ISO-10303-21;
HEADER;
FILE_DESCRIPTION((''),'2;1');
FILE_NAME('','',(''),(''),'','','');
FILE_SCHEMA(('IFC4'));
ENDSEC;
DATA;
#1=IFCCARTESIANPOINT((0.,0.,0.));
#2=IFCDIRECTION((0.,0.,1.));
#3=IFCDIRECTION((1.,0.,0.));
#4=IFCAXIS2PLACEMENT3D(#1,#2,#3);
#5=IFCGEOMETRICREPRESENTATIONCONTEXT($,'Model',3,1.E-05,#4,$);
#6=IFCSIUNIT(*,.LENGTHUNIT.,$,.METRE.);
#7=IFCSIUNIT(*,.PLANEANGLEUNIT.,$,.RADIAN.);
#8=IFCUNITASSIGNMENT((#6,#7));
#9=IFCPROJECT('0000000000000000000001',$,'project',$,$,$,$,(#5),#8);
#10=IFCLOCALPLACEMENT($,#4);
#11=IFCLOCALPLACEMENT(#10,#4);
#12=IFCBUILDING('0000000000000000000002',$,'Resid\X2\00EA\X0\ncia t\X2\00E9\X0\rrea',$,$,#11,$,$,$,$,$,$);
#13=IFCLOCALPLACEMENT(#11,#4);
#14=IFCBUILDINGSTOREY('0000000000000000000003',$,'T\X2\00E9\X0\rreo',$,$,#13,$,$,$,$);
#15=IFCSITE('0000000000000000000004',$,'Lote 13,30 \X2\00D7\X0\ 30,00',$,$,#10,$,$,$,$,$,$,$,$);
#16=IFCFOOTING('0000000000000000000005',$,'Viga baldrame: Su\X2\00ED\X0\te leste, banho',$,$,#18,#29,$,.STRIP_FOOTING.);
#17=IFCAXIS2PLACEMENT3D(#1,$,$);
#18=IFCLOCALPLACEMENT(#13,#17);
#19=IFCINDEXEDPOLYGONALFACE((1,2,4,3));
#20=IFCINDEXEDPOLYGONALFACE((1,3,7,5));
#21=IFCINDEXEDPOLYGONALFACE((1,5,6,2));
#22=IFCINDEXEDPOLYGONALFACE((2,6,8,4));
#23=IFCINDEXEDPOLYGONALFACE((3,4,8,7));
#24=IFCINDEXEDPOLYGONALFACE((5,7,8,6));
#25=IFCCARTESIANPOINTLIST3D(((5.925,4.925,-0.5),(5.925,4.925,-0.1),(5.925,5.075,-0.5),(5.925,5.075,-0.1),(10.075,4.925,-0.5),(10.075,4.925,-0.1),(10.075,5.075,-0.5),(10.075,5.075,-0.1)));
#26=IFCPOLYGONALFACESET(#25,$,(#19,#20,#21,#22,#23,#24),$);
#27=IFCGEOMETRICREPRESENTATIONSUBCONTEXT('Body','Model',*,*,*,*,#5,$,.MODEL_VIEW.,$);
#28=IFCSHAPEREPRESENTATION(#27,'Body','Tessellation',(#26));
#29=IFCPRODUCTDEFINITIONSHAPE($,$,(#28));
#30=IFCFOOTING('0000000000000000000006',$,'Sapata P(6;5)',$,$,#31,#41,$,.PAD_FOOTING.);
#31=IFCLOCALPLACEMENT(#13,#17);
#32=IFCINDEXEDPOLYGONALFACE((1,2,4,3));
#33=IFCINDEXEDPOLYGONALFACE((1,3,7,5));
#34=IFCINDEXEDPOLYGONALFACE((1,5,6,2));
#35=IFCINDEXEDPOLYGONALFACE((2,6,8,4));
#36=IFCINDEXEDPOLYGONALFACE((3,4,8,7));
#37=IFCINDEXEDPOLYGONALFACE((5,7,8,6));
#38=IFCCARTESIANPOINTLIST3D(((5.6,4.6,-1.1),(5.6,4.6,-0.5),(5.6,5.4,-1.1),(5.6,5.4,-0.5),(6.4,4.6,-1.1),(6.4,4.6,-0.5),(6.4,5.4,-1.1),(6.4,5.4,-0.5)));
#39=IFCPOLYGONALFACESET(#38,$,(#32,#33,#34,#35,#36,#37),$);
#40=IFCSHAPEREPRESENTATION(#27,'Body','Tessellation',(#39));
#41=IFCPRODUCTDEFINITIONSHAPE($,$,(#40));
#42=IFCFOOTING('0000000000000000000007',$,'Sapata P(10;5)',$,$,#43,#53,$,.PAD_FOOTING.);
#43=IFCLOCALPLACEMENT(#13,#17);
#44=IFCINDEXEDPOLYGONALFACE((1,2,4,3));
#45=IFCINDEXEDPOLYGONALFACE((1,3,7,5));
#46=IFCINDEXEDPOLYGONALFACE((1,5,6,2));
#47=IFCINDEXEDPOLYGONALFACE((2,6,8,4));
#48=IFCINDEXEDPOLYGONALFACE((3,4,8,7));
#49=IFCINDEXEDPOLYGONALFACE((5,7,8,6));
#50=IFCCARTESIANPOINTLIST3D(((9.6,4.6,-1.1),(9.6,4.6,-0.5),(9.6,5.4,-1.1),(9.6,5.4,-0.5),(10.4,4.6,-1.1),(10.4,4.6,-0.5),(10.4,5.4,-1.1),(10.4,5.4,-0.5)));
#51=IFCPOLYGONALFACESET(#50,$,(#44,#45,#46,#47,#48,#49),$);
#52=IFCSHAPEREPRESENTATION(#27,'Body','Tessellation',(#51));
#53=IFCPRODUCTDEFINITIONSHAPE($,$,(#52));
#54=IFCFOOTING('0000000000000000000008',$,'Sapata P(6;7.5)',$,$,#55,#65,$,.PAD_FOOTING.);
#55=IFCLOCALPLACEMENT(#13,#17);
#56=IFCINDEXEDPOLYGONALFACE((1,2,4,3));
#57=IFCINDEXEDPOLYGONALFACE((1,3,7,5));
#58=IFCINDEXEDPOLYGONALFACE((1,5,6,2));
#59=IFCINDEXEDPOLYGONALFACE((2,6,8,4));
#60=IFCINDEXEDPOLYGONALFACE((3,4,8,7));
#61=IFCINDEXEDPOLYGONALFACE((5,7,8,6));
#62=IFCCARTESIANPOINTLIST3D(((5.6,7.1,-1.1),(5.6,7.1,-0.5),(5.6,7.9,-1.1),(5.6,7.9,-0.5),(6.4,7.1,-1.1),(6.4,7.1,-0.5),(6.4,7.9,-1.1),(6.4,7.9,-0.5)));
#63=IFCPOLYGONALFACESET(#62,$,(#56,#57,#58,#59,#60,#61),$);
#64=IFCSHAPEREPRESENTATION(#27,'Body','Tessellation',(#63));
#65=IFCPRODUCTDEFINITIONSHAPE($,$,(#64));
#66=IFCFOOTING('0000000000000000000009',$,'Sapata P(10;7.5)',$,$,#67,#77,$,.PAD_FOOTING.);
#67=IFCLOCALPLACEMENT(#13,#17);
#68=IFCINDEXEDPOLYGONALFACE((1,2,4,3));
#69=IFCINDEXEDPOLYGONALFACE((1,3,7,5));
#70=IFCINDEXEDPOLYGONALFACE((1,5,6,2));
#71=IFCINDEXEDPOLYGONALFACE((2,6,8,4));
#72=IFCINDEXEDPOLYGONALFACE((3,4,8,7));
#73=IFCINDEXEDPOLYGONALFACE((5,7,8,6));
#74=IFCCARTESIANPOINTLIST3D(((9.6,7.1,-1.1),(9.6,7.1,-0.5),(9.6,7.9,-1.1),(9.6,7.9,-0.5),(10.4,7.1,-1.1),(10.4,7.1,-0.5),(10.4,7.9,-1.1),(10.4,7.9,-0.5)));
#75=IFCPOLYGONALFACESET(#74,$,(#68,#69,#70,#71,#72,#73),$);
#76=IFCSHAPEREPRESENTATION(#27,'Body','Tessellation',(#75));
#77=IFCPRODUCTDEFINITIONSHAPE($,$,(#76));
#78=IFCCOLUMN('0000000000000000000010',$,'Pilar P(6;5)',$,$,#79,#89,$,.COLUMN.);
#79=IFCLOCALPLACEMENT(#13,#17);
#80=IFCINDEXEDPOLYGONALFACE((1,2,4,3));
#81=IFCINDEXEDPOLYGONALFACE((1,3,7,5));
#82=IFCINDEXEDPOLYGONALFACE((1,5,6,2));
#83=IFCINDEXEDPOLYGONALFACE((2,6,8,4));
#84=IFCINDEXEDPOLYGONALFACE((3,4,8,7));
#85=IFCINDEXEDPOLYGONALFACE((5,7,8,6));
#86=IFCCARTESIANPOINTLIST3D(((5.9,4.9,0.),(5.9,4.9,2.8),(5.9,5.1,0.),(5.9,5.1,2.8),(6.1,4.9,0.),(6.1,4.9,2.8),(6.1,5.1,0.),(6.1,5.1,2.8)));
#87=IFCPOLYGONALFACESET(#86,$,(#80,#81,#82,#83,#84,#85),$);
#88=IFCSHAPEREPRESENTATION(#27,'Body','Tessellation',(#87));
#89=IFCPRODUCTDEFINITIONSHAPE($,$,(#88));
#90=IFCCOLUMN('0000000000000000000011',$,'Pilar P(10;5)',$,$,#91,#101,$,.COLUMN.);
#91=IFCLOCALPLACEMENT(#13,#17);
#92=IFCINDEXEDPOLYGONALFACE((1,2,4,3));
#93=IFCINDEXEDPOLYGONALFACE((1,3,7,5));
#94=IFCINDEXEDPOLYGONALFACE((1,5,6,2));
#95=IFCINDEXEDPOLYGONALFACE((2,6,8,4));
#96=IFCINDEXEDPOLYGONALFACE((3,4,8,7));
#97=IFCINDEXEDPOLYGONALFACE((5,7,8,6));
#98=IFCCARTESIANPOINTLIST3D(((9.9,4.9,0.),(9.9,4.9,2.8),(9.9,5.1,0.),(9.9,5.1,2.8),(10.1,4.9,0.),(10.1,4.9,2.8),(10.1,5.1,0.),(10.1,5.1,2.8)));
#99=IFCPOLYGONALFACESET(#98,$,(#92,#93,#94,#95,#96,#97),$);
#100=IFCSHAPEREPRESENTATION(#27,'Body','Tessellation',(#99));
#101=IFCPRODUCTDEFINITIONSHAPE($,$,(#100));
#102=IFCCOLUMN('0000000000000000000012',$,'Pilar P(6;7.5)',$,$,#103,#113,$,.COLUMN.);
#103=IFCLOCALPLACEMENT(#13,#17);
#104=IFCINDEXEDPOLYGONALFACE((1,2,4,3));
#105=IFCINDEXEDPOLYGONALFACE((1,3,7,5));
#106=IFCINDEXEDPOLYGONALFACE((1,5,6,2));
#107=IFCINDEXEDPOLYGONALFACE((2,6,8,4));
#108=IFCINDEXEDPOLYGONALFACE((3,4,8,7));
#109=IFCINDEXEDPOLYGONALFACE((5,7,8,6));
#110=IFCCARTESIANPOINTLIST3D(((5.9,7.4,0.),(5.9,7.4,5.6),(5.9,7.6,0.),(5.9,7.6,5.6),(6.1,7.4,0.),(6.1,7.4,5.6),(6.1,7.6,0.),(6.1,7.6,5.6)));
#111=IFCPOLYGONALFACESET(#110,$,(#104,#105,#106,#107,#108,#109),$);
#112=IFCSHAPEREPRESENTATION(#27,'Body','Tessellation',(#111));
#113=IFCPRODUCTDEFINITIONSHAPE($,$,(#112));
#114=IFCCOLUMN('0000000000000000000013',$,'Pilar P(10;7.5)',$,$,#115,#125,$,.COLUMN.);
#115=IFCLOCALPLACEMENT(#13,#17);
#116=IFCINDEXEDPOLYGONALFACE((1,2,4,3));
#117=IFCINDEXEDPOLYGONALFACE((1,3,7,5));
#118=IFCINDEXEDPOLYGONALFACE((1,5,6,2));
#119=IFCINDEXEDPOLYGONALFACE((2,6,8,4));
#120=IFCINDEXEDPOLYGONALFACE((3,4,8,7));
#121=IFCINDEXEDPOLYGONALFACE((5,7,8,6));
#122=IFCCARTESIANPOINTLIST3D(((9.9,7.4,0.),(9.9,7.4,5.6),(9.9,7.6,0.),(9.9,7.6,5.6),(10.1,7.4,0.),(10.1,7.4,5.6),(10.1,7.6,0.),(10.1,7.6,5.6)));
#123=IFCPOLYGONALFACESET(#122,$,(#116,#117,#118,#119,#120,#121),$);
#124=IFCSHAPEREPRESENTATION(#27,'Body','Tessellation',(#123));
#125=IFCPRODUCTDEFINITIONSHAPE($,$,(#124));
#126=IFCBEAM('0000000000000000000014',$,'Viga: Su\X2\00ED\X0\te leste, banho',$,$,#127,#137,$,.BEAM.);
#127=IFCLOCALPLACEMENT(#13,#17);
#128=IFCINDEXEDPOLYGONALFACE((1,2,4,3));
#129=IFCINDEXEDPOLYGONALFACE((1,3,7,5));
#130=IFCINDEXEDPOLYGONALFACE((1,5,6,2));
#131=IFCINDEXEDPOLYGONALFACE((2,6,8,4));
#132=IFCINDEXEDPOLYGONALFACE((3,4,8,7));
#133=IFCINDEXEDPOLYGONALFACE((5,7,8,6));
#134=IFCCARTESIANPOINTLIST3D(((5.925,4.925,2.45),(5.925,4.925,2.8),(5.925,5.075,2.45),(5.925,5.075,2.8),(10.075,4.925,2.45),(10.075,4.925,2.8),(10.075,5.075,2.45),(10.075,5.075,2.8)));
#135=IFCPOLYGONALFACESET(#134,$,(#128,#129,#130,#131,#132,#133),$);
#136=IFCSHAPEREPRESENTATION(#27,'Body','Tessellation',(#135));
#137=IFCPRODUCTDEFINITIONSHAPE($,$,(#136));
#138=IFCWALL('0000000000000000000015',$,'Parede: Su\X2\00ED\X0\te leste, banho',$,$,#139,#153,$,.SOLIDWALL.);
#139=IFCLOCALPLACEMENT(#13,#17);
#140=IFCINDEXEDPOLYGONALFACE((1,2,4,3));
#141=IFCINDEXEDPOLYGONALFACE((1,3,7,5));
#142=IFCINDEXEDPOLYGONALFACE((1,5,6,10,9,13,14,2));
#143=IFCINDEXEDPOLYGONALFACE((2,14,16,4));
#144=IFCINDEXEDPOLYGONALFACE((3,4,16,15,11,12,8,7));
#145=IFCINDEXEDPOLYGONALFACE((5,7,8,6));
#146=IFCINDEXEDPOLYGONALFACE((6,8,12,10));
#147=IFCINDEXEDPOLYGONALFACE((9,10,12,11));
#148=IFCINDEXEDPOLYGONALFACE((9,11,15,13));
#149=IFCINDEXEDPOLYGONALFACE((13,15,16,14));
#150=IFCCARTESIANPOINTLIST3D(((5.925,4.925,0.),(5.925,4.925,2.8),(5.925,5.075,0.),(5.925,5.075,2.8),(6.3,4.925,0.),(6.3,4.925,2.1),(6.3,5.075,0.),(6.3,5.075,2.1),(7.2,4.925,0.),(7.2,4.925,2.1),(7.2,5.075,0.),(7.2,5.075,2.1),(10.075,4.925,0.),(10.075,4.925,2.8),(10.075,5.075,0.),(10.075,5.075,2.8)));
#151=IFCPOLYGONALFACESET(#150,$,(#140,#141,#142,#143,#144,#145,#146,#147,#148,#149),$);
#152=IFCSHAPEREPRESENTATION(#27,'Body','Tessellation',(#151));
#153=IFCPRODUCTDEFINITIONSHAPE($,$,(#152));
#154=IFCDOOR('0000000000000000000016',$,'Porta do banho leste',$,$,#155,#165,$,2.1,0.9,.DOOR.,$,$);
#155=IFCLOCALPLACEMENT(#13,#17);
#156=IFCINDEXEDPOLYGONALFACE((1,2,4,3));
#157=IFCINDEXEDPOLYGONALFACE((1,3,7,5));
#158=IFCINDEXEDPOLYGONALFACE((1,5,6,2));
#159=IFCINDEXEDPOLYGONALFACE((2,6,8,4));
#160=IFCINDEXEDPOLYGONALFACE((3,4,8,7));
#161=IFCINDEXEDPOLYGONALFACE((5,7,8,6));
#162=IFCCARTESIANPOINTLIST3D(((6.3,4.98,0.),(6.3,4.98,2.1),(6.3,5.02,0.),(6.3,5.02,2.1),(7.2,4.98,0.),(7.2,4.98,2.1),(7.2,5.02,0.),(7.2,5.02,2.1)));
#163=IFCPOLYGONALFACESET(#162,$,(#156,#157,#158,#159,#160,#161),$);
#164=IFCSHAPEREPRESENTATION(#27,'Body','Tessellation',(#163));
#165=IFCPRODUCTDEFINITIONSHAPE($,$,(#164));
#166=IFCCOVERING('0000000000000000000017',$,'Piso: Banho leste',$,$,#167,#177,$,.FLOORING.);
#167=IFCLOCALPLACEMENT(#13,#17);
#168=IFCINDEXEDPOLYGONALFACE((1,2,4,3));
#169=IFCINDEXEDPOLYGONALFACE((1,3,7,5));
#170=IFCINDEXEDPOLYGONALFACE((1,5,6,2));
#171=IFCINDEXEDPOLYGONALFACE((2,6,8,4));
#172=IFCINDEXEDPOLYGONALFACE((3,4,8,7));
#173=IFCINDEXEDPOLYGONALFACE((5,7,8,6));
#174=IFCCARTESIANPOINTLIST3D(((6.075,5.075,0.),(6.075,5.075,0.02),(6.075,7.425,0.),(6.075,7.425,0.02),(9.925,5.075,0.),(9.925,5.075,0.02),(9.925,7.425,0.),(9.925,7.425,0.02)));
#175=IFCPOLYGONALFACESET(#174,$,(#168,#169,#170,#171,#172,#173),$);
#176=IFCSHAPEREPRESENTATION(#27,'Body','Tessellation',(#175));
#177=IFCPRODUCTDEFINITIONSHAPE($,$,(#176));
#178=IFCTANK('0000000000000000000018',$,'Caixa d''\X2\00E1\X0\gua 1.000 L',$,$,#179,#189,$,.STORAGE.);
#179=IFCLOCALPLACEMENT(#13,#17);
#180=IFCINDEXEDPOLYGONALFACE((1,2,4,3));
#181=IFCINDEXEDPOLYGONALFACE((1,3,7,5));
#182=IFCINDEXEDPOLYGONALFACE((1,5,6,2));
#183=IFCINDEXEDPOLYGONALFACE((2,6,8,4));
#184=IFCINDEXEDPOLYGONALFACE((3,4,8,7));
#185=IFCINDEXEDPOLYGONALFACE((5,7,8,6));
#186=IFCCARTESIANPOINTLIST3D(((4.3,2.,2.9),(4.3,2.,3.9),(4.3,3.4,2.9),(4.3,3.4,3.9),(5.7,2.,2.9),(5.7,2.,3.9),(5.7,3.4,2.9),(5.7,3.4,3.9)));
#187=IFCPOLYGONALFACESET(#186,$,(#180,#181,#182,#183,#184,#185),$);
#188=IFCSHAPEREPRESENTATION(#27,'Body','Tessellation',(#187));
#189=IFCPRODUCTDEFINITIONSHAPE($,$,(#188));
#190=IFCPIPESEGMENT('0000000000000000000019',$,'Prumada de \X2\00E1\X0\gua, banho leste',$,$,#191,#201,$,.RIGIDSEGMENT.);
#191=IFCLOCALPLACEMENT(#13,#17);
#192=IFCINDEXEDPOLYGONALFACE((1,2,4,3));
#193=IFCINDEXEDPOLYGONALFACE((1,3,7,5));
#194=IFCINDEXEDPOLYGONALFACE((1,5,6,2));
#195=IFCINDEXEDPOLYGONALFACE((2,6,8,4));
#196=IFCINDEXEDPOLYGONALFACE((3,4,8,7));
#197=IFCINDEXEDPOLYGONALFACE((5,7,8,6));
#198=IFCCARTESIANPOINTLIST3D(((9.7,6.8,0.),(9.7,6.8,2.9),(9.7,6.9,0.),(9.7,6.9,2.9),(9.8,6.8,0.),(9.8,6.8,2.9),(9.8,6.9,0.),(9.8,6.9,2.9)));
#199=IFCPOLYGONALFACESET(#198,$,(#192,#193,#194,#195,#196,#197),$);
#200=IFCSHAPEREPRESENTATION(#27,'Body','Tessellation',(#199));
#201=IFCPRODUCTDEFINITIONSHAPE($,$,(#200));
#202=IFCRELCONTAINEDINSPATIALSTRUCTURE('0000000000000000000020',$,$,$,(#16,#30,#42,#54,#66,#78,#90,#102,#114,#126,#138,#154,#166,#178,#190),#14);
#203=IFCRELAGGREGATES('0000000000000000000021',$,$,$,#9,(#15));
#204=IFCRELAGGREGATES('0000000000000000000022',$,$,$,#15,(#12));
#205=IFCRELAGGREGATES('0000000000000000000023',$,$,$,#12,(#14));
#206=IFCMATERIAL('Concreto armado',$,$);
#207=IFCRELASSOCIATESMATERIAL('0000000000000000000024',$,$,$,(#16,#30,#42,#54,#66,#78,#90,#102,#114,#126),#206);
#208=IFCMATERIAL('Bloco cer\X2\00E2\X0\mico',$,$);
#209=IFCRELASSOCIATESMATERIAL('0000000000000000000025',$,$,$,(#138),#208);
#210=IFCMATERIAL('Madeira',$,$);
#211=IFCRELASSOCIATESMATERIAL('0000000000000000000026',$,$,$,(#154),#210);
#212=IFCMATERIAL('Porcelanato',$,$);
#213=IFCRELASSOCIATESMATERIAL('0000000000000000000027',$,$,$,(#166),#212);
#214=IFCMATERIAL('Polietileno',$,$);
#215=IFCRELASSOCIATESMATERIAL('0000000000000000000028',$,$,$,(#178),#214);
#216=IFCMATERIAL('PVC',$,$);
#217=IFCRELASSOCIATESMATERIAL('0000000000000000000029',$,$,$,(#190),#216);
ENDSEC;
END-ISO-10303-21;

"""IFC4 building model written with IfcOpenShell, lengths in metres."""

from ifc_helpers import new_model, si_unit, frame, origin_with_axes, place, context, subcontext, project, spatial, line, indexed_curve, outline, extrude, material, element, fill, save


model = new_model("IFC4")

# Units and contexts
model_context = context("Model", 3, precision=1e-05, world=origin_with_axes())
body_context = subcontext(model_context, "Body", "Model", "MODEL_VIEW")
ifc_project = project(units=[si_unit("LENGTHUNIT", "METRE"), si_unit("PLANEANGLEUNIT", "RADIAN")], contexts=[model_context])

# Site, building, storey
site_placement = place(None, origin_with_axes())
site = spatial("IfcSite", under=ifc_project, at=site_placement, Name="Lote 13,30 × 30,00")
building_placement = place(site_placement, origin_with_axes())
building = spatial("IfcBuilding", under=site, at=building_placement, Name="Residência térrea")
storey_placement = place(building_placement, origin_with_axes())
storey = spatial("IfcBuildingStorey", under=building, at=storey_placement, Name="Térreo")

# Footings
ifc_material_1 = material(Name="Concreto armado")
footing_placement = place(storey_placement, frame((5.925, 4.925, -0.5), z_axis=(0.0, 0.0, 1.0), x_axis=(1.0, 0.0, 0.0)))
element("IfcFooting", 1, at=footing_placement, inside=storey, material=ifc_material_1, Name="Viga baldrame: Suíte leste, banho", PredefinedType="STRIP_FOOTING", context=body_context, shape_type="SweptSolid", body=[
    extrude(outline(indexed_curve([(0.0, 0.0), (4.15, 0.0), (4.15, 0.15), (0.0, 0.15)], segments=[line(1, 2, 3, 4, 1)])), origin_with_axes(), (0.0, 0.0, 1.0), 0.4),
])
for number, where, z_axis, x_axis, name in (
    (2, (5.6, 4.6, -1.1), (0.0, 0.0, 1.0), (1.0, 0.0, 0.0), "Sapata P(6;5)"),
    (3, (9.6, 4.6, -1.1), (0.0, 0.0, 1.0), (1.0, 0.0, 0.0), "Sapata P(10;5)"),
    (4, (5.6, 7.1, -1.1), (0.0, 0.0, 1.0), (1.0, 0.0, 0.0), "Sapata P(6;7.5)"),
    (5, (9.6, 7.1, -1.1), (0.0, 0.0, 1.0), (1.0, 0.0, 0.0), "Sapata P(10;7.5)"),
):
    element("IfcFooting", number, at=place(storey_placement, frame(where, z_axis=z_axis, x_axis=x_axis)), inside=storey, material=ifc_material_1, Name=name, PredefinedType="PAD_FOOTING", context=body_context, shape_type="SweptSolid", body=[
        extrude(outline(indexed_curve([(0.0, 0.0), (0.8, 0.0), (0.8, 0.8), (0.0, 0.8)], segments=[line(1, 2, 3, 4, 1)])), origin_with_axes(), (0.0, 0.0, 1.0), 0.6),
    ])

# Columns
for number, where, z_axis, x_axis, name in (
    (6, (5.9, 4.9, 0.0), (0.0, 0.0, 1.0), (1.0, 0.0, 0.0), "Pilar P(6;5)"),
    (7, (9.9, 4.9, 0.0), (0.0, 0.0, 1.0), (1.0, 0.0, 0.0), "Pilar P(10;5)"),
):
    element("IfcColumn", number, at=place(storey_placement, frame(where, z_axis=z_axis, x_axis=x_axis)), inside=storey, material=ifc_material_1, Name=name, PredefinedType="COLUMN", context=body_context, shape_type="SweptSolid", body=[
        extrude(outline(indexed_curve([(0.0, 0.0), (0.2, 0.0), (0.2, 0.2), (0.0, 0.2)], segments=[line(1, 2, 3, 4, 1)])), origin_with_axes(), (0.0, 0.0, 1.0), 2.8),
    ])
for number, where, z_axis, x_axis, name in (
    (8, (5.9, 7.4, 0.0), (0.0, 0.0, 1.0), (1.0, 0.0, 0.0), "Pilar P(6;7.5)"),
    (9, (9.9, 7.4, 0.0), (0.0, 0.0, 1.0), (1.0, 0.0, 0.0), "Pilar P(10;7.5)"),
):
    element("IfcColumn", number, at=place(storey_placement, frame(where, z_axis=z_axis, x_axis=x_axis)), inside=storey, material=ifc_material_1, Name=name, PredefinedType="COLUMN", context=body_context, shape_type="SweptSolid", body=[
        extrude(outline(indexed_curve([(0.0, 0.0), (0.2, 0.0), (0.2, 0.2), (0.0, 0.2)], segments=[line(1, 2, 3, 4, 1)])), origin_with_axes(), (0.0, 0.0, 1.0), 5.6),
    ])

# Beam
beam_placement = place(storey_placement, frame((5.925, 4.925, 2.45), z_axis=(0.0, 0.0, 1.0), x_axis=(1.0, 0.0, 0.0)))
element("IfcBeam", 10, at=beam_placement, inside=storey, material=ifc_material_1, Name="Viga: Suíte leste, banho", PredefinedType="BEAM", context=body_context, shape_type="SweptSolid", body=[
    extrude(outline(indexed_curve([(0.0, 0.0), (4.15, 0.0), (4.15, 0.15), (0.0, 0.15)], segments=[line(1, 2, 3, 4, 1)])), origin_with_axes(), (0.0, 0.0, 1.0), 0.35),
])

# Wall, opening, door
ifc_material_2 = material(Name="Bloco cerâmico")
wall_placement = place(storey_placement, frame((5.925, 4.925, 0.0), z_axis=(0.0, 0.0, 1.0), x_axis=(1.0, 0.0, 0.0)))
wall = element("IfcWall", 11, at=wall_placement, inside=storey, material=ifc_material_2, Name="Parede: Suíte leste, banho", PredefinedType="SOLIDWALL", context=body_context, shape_type="SweptSolid", body=[
    extrude(outline(indexed_curve([(0.0, 0.0), (4.15, 0.0), (4.15, 0.15), (0.0, 0.15)], segments=[line(1, 2, 3, 4, 1)])), origin_with_axes(), (0.0, 0.0, 1.0), 2.8),
])
opening_placement = place(wall_placement, frame((0.375, -0.05, 0.0), z_axis=(0.0, 0.0, 1.0), x_axis=(1.0, 0.0, 0.0)))
opening = element("IfcOpeningElement", 12, at=opening_placement, cuts=wall, material=ifc_material_1, PredefinedType="OPENING", context=body_context, shape_type="SweptSolid", body=[
    extrude(outline(indexed_curve([(0.0, 0.0), (0.9, 0.0), (0.9, 0.25), (0.0, 0.25)], segments=[line(1, 2, 3, 4, 1)])), origin_with_axes(), (0.0, 0.0, 1.0), 2.1),
])
ifc_material_3 = material(Name="Madeira")
door_placement = place(storey_placement, frame((6.3, 4.98, 0.0), z_axis=(0.0, 0.0, 1.0), x_axis=(1.0, 0.0, 0.0)))
door = element("IfcDoor", 13, at=door_placement, inside=storey, material=ifc_material_3, Name="Porta do banho leste", OverallHeight=2.1, OverallWidth=0.9, PredefinedType="DOOR", context=body_context, shape_type="SweptSolid", body=[
    extrude(outline(indexed_curve([(0.0, 0.0), (0.9, 0.0), (0.9, 0.04), (0.0, 0.04)], segments=[line(1, 2, 3, 4, 1)])), origin_with_axes(), (0.0, 0.0, 1.0), 2.1),
])
fill(opening, door)

# Covering
ifc_material_4 = material(Name="Porcelanato")
covering_placement = place(storey_placement, frame((6.075, 5.075, 0.0), z_axis=(0.0, 0.0, 1.0), x_axis=(1.0, 0.0, 0.0)))
element("IfcCovering", 14, at=covering_placement, inside=storey, material=ifc_material_4, Name="Piso: Banho leste", PredefinedType="FLOORING", context=body_context, shape_type="SweptSolid", body=[
    extrude(outline(indexed_curve([(0.0, 0.0), (3.85, 0.0), (3.85, 2.35), (0.0, 2.35)], segments=[line(1, 2, 3, 4, 1)])), origin_with_axes(), (0.0, 0.0, 1.0), 0.02),
])

# Tank
ifc_material_5 = material(Name="Polietileno")
tank_placement = place(storey_placement, frame((4.3, 2.0, 2.9), z_axis=(0.0, 0.0, 1.0), x_axis=(1.0, 0.0, 0.0)))
element("IfcTank", 15, at=tank_placement, inside=storey, material=ifc_material_5, Name="Caixa d'água 1.000 L", PredefinedType="STORAGE", context=body_context, shape_type="SweptSolid", body=[
    extrude(outline(indexed_curve([(0.0, 0.0), (1.4, 0.0), (1.4, 1.4), (0.0, 1.4)], segments=[line(1, 2, 3, 4, 1)])), origin_with_axes(), (0.0, 0.0, 1.0), 1.0),
])

# Pipe segment
ifc_material_6 = material(Name="PVC")
pipe_segment_placement = place(storey_placement, frame((9.7, 6.8, 0.0), z_axis=(0.0, 0.0, 1.0), x_axis=(1.0, 0.0, 0.0)))
element("IfcPipeSegment", 16, at=pipe_segment_placement, inside=storey, material=ifc_material_6, Name="Prumada de água, banho leste", PredefinedType="RIGIDSEGMENT", context=body_context, shape_type="SweptSolid", body=[
    extrude(outline(indexed_curve([(0.0, 0.0), (0.1, 0.0), (0.1, 0.1), (0.0, 0.1)], segments=[line(1, 2, 3, 4, 1)])), origin_with_axes(), (0.0, 0.0, 1.0), 2.9),
])

save(model, "model.ifc")
